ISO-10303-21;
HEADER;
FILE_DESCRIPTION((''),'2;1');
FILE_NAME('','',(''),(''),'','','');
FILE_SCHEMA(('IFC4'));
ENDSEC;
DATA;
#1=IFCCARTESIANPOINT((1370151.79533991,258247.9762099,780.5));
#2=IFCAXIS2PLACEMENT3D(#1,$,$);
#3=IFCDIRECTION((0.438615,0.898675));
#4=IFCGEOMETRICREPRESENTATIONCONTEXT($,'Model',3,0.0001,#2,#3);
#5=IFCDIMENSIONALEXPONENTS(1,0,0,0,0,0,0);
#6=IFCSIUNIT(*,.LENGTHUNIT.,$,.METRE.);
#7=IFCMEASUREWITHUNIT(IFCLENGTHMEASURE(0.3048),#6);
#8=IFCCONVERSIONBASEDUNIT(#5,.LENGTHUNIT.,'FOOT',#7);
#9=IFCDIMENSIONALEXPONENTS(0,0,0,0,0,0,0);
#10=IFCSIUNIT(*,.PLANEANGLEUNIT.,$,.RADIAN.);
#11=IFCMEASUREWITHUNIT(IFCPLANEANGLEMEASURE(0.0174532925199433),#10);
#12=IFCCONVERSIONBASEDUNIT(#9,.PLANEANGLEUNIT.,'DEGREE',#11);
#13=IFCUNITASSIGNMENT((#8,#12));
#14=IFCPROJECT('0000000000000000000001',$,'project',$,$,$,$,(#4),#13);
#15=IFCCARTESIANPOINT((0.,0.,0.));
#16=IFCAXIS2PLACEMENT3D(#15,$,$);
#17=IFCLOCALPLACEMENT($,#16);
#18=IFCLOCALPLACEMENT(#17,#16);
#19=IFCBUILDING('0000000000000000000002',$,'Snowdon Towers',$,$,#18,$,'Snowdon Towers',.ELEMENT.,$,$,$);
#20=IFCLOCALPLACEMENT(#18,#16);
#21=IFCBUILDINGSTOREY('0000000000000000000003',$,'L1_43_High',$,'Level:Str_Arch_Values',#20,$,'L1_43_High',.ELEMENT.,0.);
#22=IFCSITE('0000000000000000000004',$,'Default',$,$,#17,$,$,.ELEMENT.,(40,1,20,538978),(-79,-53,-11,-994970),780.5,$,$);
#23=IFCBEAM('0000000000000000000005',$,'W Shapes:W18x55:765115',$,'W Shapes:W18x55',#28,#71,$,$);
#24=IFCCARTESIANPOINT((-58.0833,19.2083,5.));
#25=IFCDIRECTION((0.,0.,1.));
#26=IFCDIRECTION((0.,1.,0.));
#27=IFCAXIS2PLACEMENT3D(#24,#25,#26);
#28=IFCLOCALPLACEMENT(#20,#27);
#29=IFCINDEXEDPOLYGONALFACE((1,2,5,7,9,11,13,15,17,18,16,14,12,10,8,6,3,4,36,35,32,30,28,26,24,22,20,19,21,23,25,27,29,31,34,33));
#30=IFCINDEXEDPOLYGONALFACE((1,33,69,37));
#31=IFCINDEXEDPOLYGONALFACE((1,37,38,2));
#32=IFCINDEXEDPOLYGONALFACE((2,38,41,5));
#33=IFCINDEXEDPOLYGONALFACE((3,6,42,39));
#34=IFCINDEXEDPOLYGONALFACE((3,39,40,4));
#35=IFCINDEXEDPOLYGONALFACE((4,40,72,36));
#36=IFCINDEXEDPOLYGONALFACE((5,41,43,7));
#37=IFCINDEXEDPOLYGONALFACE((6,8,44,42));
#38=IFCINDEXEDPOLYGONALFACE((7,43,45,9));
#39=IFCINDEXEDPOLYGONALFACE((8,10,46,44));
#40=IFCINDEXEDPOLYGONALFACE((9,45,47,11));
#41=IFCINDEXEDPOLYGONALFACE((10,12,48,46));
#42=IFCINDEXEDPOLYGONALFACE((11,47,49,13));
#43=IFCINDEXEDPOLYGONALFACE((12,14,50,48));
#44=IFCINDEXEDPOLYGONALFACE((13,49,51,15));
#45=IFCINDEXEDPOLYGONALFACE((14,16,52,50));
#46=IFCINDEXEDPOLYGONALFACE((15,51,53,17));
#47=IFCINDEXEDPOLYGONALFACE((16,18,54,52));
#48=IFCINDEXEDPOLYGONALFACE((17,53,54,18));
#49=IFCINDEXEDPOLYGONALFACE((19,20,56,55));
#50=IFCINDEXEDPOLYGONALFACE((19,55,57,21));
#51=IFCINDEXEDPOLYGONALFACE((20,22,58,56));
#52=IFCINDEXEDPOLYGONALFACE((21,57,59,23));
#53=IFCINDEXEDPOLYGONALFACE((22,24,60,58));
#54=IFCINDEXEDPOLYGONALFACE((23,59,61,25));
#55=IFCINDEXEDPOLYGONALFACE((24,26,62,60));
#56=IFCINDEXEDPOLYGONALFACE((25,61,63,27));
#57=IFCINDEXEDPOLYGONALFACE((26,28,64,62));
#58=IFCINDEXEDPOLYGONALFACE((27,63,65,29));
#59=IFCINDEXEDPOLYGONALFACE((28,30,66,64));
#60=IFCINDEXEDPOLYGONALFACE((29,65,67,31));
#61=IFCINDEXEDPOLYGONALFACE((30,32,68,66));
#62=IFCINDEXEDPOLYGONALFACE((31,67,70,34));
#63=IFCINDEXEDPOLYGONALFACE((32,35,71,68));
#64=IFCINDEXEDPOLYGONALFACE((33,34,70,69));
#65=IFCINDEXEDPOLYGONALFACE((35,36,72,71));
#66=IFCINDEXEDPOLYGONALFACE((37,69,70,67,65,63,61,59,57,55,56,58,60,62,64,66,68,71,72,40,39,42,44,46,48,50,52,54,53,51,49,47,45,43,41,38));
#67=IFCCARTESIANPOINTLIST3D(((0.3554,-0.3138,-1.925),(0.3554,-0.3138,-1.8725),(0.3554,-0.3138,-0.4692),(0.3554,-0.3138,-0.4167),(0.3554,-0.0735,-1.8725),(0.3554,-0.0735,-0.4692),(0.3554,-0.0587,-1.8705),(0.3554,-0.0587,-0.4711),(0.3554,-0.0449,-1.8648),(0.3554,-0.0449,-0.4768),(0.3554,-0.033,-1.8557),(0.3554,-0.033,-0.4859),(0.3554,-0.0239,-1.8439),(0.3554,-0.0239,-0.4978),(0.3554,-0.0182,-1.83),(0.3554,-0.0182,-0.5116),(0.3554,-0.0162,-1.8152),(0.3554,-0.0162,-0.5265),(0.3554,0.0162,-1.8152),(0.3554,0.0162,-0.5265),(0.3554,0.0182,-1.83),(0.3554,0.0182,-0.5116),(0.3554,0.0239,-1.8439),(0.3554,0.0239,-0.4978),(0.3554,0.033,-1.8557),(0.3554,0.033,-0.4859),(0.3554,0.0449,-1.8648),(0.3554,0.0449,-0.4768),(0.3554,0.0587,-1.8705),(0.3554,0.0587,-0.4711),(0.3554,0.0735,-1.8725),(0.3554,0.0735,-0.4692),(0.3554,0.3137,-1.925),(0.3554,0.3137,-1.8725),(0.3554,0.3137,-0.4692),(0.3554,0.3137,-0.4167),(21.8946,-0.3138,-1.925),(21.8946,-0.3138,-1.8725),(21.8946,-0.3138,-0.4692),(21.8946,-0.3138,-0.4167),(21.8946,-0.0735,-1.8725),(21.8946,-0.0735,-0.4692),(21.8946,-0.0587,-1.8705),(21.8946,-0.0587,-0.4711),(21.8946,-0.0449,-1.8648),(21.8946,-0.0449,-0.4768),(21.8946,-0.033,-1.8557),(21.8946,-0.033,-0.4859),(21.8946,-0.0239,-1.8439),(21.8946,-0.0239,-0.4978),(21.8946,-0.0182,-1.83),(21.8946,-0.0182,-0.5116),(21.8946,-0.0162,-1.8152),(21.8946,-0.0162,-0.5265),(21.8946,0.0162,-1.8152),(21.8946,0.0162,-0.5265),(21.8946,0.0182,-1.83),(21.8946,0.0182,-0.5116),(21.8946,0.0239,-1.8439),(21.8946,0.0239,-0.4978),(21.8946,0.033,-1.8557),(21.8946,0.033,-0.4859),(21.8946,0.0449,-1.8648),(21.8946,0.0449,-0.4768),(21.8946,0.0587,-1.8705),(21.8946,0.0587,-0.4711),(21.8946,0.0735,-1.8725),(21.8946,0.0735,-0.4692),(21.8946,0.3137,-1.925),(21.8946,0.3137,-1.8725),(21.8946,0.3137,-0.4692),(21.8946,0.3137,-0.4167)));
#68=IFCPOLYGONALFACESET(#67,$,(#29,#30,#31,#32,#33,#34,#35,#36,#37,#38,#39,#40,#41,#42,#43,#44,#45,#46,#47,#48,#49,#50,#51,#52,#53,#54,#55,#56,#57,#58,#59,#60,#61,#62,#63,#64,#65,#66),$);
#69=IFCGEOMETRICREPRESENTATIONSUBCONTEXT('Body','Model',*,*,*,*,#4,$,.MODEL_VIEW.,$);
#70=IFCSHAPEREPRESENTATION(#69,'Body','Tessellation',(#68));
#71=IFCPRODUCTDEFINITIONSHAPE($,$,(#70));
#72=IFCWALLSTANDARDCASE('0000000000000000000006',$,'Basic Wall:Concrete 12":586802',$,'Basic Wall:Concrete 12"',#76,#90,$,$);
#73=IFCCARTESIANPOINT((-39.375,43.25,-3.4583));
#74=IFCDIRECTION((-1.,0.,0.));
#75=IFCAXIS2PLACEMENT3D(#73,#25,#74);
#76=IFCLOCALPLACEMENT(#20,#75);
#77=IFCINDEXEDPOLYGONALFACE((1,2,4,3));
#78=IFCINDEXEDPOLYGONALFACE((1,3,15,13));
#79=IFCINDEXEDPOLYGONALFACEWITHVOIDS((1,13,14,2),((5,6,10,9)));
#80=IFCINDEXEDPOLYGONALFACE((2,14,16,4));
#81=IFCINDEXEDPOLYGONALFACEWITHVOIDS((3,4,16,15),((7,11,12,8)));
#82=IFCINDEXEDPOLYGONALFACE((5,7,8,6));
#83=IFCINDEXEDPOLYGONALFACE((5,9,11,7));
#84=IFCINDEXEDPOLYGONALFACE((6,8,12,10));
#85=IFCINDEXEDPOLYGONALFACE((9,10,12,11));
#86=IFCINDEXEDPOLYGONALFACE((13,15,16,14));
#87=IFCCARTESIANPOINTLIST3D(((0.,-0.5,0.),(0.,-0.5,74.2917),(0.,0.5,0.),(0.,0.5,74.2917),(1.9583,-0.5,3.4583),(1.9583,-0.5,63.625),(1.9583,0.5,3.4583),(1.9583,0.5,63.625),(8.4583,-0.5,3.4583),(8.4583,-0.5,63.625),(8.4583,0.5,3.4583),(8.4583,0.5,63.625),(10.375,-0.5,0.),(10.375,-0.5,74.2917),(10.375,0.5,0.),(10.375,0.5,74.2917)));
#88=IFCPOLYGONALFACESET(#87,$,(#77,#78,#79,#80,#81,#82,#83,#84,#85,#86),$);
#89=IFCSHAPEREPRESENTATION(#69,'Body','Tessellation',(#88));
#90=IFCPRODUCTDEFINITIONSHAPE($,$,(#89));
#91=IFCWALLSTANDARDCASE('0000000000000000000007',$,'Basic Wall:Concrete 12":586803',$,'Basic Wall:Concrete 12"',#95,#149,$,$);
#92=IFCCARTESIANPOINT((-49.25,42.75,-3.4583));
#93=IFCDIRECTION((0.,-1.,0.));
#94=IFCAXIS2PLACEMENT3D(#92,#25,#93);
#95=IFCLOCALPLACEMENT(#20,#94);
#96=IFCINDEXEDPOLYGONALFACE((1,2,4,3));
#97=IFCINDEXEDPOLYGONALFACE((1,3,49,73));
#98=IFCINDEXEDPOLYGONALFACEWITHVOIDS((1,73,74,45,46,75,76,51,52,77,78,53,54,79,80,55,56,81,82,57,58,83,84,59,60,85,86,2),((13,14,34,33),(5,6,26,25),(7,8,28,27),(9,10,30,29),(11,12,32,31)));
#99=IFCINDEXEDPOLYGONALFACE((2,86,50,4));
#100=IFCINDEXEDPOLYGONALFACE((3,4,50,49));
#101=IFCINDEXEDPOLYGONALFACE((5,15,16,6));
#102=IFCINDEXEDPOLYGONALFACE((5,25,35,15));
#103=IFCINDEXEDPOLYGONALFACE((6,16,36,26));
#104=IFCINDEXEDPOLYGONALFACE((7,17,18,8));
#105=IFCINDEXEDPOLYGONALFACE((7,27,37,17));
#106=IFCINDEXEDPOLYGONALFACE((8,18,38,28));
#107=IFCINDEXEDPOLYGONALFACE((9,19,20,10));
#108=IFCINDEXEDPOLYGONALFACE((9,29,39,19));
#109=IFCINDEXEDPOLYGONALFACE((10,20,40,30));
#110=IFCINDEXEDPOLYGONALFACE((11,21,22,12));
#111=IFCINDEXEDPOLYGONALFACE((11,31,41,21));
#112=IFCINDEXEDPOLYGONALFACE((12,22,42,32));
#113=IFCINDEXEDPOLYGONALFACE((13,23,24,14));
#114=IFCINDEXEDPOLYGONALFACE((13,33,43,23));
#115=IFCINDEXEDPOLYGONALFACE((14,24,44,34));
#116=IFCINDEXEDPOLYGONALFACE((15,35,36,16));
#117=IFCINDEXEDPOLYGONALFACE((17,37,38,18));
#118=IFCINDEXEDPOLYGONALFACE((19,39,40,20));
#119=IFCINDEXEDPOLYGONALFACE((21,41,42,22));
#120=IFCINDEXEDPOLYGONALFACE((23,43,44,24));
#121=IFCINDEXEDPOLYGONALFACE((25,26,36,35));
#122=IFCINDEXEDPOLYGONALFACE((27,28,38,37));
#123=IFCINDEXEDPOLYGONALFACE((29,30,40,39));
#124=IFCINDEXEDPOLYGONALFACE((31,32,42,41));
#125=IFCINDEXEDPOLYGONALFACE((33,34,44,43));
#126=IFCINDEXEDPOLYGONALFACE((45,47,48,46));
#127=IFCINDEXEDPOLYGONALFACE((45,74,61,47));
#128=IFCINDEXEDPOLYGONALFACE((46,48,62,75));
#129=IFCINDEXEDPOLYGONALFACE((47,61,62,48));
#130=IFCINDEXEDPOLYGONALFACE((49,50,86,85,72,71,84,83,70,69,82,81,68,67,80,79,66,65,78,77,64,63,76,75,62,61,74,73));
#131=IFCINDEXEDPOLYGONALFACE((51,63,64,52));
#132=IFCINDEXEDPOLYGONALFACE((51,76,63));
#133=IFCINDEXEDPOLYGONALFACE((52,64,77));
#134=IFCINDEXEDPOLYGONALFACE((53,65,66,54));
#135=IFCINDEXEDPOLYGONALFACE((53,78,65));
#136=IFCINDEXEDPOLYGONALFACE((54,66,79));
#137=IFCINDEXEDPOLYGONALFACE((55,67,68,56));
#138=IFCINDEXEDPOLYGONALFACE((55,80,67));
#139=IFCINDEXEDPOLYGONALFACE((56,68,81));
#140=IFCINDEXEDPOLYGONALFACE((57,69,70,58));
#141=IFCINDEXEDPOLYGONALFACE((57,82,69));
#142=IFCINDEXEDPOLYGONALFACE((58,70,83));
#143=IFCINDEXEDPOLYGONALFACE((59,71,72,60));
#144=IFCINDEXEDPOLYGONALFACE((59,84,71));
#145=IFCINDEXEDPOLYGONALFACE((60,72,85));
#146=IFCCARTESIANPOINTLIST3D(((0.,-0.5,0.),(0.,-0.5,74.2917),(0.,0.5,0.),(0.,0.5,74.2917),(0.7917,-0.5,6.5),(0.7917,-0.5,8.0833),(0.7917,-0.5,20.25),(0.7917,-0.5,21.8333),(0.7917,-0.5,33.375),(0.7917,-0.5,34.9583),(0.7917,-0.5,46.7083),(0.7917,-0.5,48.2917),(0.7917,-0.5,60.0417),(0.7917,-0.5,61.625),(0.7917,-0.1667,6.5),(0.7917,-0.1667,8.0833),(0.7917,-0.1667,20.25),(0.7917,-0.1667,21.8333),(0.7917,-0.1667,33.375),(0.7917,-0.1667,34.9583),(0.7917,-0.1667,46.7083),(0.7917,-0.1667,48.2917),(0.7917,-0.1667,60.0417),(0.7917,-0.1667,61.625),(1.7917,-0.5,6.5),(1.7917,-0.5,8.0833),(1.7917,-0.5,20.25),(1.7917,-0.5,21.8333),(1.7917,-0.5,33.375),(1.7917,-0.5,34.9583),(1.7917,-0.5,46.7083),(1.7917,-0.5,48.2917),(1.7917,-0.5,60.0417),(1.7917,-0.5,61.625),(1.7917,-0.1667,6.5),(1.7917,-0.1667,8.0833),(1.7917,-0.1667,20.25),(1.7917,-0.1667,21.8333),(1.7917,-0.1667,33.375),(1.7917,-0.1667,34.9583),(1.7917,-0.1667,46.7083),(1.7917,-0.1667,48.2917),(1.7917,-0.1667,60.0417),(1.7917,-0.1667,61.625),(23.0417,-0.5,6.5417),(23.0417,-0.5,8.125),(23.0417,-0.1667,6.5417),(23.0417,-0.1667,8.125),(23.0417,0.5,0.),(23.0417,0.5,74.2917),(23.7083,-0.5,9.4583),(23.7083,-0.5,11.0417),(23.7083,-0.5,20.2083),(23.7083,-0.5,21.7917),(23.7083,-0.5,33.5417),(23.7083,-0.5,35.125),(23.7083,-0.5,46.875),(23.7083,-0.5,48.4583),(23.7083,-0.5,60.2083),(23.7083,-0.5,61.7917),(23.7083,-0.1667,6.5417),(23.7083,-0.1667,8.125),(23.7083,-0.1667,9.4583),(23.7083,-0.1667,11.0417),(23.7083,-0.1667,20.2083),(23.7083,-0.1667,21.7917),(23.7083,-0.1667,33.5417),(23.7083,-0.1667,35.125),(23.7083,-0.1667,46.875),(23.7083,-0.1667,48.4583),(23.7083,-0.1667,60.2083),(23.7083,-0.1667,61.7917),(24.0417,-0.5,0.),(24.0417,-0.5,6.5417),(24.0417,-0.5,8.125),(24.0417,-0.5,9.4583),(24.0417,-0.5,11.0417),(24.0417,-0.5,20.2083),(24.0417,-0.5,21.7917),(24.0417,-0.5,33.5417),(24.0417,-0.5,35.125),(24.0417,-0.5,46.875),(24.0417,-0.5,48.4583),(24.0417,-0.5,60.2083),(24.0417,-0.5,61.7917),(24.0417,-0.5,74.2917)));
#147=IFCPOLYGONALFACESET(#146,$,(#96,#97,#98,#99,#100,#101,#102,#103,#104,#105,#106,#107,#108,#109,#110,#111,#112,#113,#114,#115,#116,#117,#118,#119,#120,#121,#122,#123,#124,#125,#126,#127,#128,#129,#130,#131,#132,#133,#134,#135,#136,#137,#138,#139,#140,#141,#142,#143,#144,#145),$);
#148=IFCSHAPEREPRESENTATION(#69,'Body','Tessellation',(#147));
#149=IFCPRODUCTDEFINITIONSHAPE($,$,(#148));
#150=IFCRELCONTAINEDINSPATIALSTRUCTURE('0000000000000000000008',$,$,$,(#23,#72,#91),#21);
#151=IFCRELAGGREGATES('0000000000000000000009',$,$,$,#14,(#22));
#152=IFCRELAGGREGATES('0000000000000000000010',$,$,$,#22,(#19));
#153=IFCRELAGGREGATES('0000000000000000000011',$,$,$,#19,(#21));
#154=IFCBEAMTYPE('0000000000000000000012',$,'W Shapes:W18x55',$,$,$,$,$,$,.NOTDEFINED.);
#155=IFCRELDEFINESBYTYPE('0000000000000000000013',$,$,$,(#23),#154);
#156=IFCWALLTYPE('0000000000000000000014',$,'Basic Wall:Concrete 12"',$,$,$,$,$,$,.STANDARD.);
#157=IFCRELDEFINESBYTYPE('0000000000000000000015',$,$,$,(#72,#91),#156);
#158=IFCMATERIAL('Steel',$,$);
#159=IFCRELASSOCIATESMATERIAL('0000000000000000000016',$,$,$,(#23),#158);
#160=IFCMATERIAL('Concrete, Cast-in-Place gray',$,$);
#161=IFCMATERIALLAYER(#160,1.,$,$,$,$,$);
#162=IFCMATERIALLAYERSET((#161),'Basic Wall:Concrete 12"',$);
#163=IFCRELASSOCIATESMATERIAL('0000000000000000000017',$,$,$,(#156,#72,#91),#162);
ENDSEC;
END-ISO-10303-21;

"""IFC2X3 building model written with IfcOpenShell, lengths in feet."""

from ifc_helpers import new_model, entity, si_unit, converted_unit, direction, frame, frame_2d, origin, origin_2d_with_axis, place, context, subcontext, project, spatial, polyline, rectangle, i_section, outline, extrude, material, layer, layer_set, layer_usage, type_object, element, save


model = new_model("IFC2X3")

# Units and contexts
model_context = context("Model", 3, precision=0.0001, world=frame((1370151.79533991, 258247.9762099, 780.5)), true_north=direction((0.438615, 0.898675)))
body_context = subcontext(model_context, "Body", "Model", "MODEL_VIEW")
ifc_project = project(units=[converted_unit("LENGTHUNIT", "FOOT", entity("IfcLengthMeasure", 0.3048), si_unit("LENGTHUNIT", "METRE"), dimensions=[1, 0, 0, 0, 0, 0, 0]), converted_unit("PLANEANGLEUNIT", "DEGREE", entity("IfcPlaneAngleMeasure", 0.0174532925199433), si_unit("PLANEANGLEUNIT", "RADIAN"), dimensions=[0, 0, 0, 0, 0, 0, 0])], contexts=[model_context])

# Site, building, storey
site_placement = place(None, origin())
site = spatial("IfcSite", under=ifc_project, at=site_placement, Name="Default", CompositionType="ELEMENT", RefLatitude=(40, 1, 20, 538978), RefLongitude=(-79, -53, -11, -994970), RefElevation=780.5)
building_placement = place(site_placement, origin())
building = spatial("IfcBuilding", under=site, at=building_placement, Name="Snowdon Towers", LongName="Snowdon Towers", CompositionType="ELEMENT")
storey_placement = place(building_placement, origin())
storey = spatial("IfcBuildingStorey", under=building, at=storey_placement, Name="L1_43_High", ObjectType="Level:Str_Arch_Values", LongName="L1_43_High", CompositionType="ELEMENT", Elevation=0.0)

# Beam
ifc_material_1 = material(Name="Steel")
beam_type = type_object("IfcBeamType", Name="W Shapes:W18x55", PredefinedType="NOTDEFINED")
beam_1_placement = place(storey_placement, frame((-58.0833, 19.2083, 5.0), z_axis=(0.0, 0.0, 1.0), x_axis=(0.0, 1.0, 0.0)))
element("IfcBeam", 1, at=beam_1_placement, inside=storey, type_object=beam_type, material=ifc_material_1, Name="W Shapes:W18x55:765115", ObjectType="W Shapes:W18x55", context=body_context, shape_type="SweptSolid", body=[
    extrude(i_section(OverallWidth=0.6275, OverallDepth=1.5083, WebThickness=0.0325, FlangeThickness=0.0525, FilletRadius=0.0573, at=frame_2d((0.0, 0.0), x_axis=(0.0, 1.0))), frame((0.3554, 0.0, -1.1708), z_axis=(1.0, 0.0, 0.0), x_axis=(0.0, 0.0, -1.0)), (0.0, 0.0, 1.0), 21.5392),
])

# Shared definitions
ifc_material_2 = material(Name="Concrete, Cast-in-Place gray")

# Shared definitions
ifc_layer_1 = layer(ifc_material_2, 1.0)
ifc_layer_set_1 = layer_set([ifc_layer_1], Name="Basic Wall:Concrete 12\"")
wall_type = type_object("IfcWallType", Name="Basic Wall:Concrete 12\"", PredefinedType="STANDARD", material=ifc_layer_set_1)

# Wall, opening
ifc_layer_usage_1 = layer_usage(ifc_layer_set_1, "AXIS2", "POSITIVE", -0.5)
wall_1_placement = place(storey_placement, frame((-39.375, 43.25, -3.4583), z_axis=(0.0, 0.0, 1.0), x_axis=(-1.0, 0.0, 0.0)))
wall_1 = element("IfcWallStandardCase", 2, at=wall_1_placement, inside=storey, type_object=wall_type, material=ifc_layer_usage_1, Name="Basic Wall:Concrete 12\":586802", ObjectType="Basic Wall:Concrete 12\"", context=body_context, shape_type="SweptSolid", body=[
    extrude(rectangle(XDim=10.375, YDim=1.0, at=frame_2d((5.1875, 0.0), x_axis=(-1.0, 0.0))), origin(), (0.0, 0.0, 1.0), 74.2917),
])
opening_1_placement = place(wall_1_placement, origin())
element("IfcOpeningElement", 3, at=opening_1_placement, cuts=wall_1, ObjectType="Opening", context=body_context, shape_type="SweptSolid", body=[
    extrude(rectangle(XDim=60.1667, YDim=6.5, at=frame_2d((0.0, 0.0), x_axis=(1.0, 0.0))), frame((5.2083, -4.5, 33.5417), z_axis=(0.0, 1.0, 0.0), x_axis=(0.0, 0.0, 1.0)), (0.0, 0.0, 1.0), 10.0),
])

# Wall, openings
ifc_layer_usage_2 = layer_usage(ifc_layer_set_1, "AXIS2", "POSITIVE", -0.5)
wall_2_placement = place(storey_placement, frame((-49.25, 42.75, -3.4583), z_axis=(0.0, 0.0, 1.0), x_axis=(0.0, -1.0, 0.0)))
wall_2 = element("IfcWallStandardCase", 4, at=wall_2_placement, inside=storey, type_object=wall_type, material=ifc_layer_usage_2, Name="Basic Wall:Concrete 12\":586803", ObjectType="Basic Wall:Concrete 12\"", context=body_context, shape_type="SweptSolid", body=[
    extrude(outline(polyline([(24.0417, -0.5), (23.0417, 0.5), (0.0, 0.5), (0.0, -0.5), (24.0417, -0.5)])), origin(), (0.0, 0.0, 1.0), 74.2917),
])
opening_2_placement = place(wall_2_placement, origin())
element("IfcOpeningElement", 5, at=opening_2_placement, cuts=wall_2, ObjectType="Opening", context=body_context, shape_type="SweptSolid", body=[
    extrude(rectangle(XDim=1.5833, YDim=0.3333, at=frame_2d((0.0, 0.0), x_axis=(0.0, 1.0))), frame((23.875, -0.5, 21.0), z_axis=(0.0, 1.0, 0.0), x_axis=(1.0, 0.0, 0.0)), (0.0, 0.0, 1.0), 1.0),
])
opening_3_placement = place(wall_2_placement, origin())
element("IfcOpeningElement", 6, at=opening_3_placement, cuts=wall_2, ObjectType="Opening", context=body_context, shape_type="SweptSolid", body=[
    extrude(rectangle(XDim=1.5833, YDim=0.3333, at=frame_2d((0.0, 0.0), x_axis=(0.0, 1.0))), frame((23.875, -0.5, 10.25), z_axis=(0.0, 1.0, 0.0), x_axis=(1.0, 0.0, 0.0)), (0.0, 0.0, 1.0), 1.0),
])
opening_4_placement = place(wall_2_placement, origin())
element("IfcOpeningElement", 7, at=opening_4_placement, cuts=wall_2, ObjectType="Recess", context=body_context, shape_type="SweptSolid", body=[
    extrude(rectangle(XDim=1.5833, YDim=1.0, at=frame_2d((0.0, 0.0), x_axis=(1.0, 0.0))), frame((23.5417, -0.5, 7.3333), z_axis=(0.0, 1.0, 0.0), x_axis=(0.0, 0.0, -1.0)), (0.0, 0.0, 1.0), 0.3333),
])
opening_5_placement = place(wall_2_placement, origin())
element("IfcOpeningElement", 8, at=opening_5_placement, cuts=wall_2, ObjectType="Opening", context=body_context, shape_type="SweptSolid", body=[
    extrude(rectangle(XDim=1.5833, YDim=0.3333, at=frame_2d((0.0, 0.0), x_axis=(0.0, 1.0))), frame((23.875, -0.5, 34.3333), z_axis=(0.0, 1.0, 0.0), x_axis=(1.0, 0.0, 0.0)), (0.0, 0.0, 1.0), 1.0),
])
opening_6_placement = place(wall_2_placement, origin())
element("IfcOpeningElement", 9, at=opening_6_placement, cuts=wall_2, ObjectType="Opening", context=body_context, shape_type="SweptSolid", body=[
    extrude(rectangle(XDim=1.5833, YDim=0.3333, at=frame_2d((0.0, 0.0), x_axis=(0.0, 1.0))), frame((23.875, -0.5, 47.6667), z_axis=(0.0, 1.0, 0.0), x_axis=(1.0, 0.0, 0.0)), (0.0, 0.0, 1.0), 1.0),
])
opening_7_placement = place(wall_2_placement, origin())
element("IfcOpeningElement", 10, at=opening_7_placement, cuts=wall_2, ObjectType="Opening", context=body_context, shape_type="SweptSolid", body=[
    extrude(rectangle(XDim=1.5833, YDim=0.3333, at=frame_2d((0.0, 0.0), x_axis=(0.0, 1.0))), frame((23.875, -0.5, 61.0), z_axis=(0.0, 1.0, 0.0), x_axis=(1.0, 0.0, 0.0)), (0.0, 0.0, 1.0), 1.0),
])
opening_8_placement = place(wall_2_placement, origin())
element("IfcOpeningElement", 11, at=opening_8_placement, cuts=wall_2, ObjectType="Recess", context=body_context, shape_type="SweptSolid", body=[
    extrude(rectangle(XDim=1.5833, YDim=1.0, at=frame_2d((0.0, 0.0), x_axis=(1.0, 0.0))), frame((1.2917, -0.5, 21.0417), z_axis=(0.0, 1.0, 0.0), x_axis=(0.0, 0.0, -1.0)), (0.0, 0.0, 1.0), 0.3333),
])
opening_9_placement = place(wall_2_placement, origin())
element("IfcOpeningElement", 12, at=opening_9_placement, cuts=wall_2, ObjectType="Recess", context=body_context, shape_type="SweptSolid", body=[
    extrude(rectangle(XDim=1.5833, YDim=1.0, at=frame_2d((0.0, 0.0), x_axis=(1.0, 0.0))), frame((1.2917, -0.5, 7.2917), z_axis=(0.0, 1.0, 0.0), x_axis=(0.0, 0.0, -1.0)), (0.0, 0.0, 1.0), 0.3333),
])
opening_10_placement = place(wall_2_placement, origin())
element("IfcOpeningElement", 13, at=opening_10_placement, cuts=wall_2, ObjectType="Recess", context=body_context, shape_type="SweptSolid", body=[
    extrude(rectangle(XDim=1.5833, YDim=1.0, at=frame_2d((0.0, 0.0), x_axis=(1.0, 0.0))), frame((1.2917, -0.5, 34.1667), z_axis=(0.0, 1.0, 0.0), x_axis=(0.0, 0.0, -1.0)), (0.0, 0.0, 1.0), 0.3333),
])
opening_11_placement = place(wall_2_placement, origin())
element("IfcOpeningElement", 14, at=opening_11_placement, cuts=wall_2, ObjectType="Recess", context=body_context, shape_type="SweptSolid", body=[
    extrude(rectangle(XDim=1.5833, YDim=1.0, at=origin_2d_with_axis()), frame((1.2917, -0.5, 47.5), z_axis=(0.0, 1.0, 0.0), x_axis=(0.0, 0.0, -1.0)), (0.0, 0.0, 1.0), 0.3333),
])
opening_12_placement = place(wall_2_placement, origin())
element("IfcOpeningElement", 15, at=opening_12_placement, cuts=wall_2, ObjectType="Recess", context=body_context, shape_type="SweptSolid", body=[
    extrude(rectangle(XDim=1.5833, YDim=1.0, at=frame_2d((0.0, 0.0), x_axis=(1.0, 0.0))), frame((1.2917, -0.5, 60.8333), z_axis=(0.0, 1.0, 0.0), x_axis=(0.0, 0.0, -1.0)), (0.0, 0.0, 1.0), 0.3333),
])

save(model, "model.ifc")
